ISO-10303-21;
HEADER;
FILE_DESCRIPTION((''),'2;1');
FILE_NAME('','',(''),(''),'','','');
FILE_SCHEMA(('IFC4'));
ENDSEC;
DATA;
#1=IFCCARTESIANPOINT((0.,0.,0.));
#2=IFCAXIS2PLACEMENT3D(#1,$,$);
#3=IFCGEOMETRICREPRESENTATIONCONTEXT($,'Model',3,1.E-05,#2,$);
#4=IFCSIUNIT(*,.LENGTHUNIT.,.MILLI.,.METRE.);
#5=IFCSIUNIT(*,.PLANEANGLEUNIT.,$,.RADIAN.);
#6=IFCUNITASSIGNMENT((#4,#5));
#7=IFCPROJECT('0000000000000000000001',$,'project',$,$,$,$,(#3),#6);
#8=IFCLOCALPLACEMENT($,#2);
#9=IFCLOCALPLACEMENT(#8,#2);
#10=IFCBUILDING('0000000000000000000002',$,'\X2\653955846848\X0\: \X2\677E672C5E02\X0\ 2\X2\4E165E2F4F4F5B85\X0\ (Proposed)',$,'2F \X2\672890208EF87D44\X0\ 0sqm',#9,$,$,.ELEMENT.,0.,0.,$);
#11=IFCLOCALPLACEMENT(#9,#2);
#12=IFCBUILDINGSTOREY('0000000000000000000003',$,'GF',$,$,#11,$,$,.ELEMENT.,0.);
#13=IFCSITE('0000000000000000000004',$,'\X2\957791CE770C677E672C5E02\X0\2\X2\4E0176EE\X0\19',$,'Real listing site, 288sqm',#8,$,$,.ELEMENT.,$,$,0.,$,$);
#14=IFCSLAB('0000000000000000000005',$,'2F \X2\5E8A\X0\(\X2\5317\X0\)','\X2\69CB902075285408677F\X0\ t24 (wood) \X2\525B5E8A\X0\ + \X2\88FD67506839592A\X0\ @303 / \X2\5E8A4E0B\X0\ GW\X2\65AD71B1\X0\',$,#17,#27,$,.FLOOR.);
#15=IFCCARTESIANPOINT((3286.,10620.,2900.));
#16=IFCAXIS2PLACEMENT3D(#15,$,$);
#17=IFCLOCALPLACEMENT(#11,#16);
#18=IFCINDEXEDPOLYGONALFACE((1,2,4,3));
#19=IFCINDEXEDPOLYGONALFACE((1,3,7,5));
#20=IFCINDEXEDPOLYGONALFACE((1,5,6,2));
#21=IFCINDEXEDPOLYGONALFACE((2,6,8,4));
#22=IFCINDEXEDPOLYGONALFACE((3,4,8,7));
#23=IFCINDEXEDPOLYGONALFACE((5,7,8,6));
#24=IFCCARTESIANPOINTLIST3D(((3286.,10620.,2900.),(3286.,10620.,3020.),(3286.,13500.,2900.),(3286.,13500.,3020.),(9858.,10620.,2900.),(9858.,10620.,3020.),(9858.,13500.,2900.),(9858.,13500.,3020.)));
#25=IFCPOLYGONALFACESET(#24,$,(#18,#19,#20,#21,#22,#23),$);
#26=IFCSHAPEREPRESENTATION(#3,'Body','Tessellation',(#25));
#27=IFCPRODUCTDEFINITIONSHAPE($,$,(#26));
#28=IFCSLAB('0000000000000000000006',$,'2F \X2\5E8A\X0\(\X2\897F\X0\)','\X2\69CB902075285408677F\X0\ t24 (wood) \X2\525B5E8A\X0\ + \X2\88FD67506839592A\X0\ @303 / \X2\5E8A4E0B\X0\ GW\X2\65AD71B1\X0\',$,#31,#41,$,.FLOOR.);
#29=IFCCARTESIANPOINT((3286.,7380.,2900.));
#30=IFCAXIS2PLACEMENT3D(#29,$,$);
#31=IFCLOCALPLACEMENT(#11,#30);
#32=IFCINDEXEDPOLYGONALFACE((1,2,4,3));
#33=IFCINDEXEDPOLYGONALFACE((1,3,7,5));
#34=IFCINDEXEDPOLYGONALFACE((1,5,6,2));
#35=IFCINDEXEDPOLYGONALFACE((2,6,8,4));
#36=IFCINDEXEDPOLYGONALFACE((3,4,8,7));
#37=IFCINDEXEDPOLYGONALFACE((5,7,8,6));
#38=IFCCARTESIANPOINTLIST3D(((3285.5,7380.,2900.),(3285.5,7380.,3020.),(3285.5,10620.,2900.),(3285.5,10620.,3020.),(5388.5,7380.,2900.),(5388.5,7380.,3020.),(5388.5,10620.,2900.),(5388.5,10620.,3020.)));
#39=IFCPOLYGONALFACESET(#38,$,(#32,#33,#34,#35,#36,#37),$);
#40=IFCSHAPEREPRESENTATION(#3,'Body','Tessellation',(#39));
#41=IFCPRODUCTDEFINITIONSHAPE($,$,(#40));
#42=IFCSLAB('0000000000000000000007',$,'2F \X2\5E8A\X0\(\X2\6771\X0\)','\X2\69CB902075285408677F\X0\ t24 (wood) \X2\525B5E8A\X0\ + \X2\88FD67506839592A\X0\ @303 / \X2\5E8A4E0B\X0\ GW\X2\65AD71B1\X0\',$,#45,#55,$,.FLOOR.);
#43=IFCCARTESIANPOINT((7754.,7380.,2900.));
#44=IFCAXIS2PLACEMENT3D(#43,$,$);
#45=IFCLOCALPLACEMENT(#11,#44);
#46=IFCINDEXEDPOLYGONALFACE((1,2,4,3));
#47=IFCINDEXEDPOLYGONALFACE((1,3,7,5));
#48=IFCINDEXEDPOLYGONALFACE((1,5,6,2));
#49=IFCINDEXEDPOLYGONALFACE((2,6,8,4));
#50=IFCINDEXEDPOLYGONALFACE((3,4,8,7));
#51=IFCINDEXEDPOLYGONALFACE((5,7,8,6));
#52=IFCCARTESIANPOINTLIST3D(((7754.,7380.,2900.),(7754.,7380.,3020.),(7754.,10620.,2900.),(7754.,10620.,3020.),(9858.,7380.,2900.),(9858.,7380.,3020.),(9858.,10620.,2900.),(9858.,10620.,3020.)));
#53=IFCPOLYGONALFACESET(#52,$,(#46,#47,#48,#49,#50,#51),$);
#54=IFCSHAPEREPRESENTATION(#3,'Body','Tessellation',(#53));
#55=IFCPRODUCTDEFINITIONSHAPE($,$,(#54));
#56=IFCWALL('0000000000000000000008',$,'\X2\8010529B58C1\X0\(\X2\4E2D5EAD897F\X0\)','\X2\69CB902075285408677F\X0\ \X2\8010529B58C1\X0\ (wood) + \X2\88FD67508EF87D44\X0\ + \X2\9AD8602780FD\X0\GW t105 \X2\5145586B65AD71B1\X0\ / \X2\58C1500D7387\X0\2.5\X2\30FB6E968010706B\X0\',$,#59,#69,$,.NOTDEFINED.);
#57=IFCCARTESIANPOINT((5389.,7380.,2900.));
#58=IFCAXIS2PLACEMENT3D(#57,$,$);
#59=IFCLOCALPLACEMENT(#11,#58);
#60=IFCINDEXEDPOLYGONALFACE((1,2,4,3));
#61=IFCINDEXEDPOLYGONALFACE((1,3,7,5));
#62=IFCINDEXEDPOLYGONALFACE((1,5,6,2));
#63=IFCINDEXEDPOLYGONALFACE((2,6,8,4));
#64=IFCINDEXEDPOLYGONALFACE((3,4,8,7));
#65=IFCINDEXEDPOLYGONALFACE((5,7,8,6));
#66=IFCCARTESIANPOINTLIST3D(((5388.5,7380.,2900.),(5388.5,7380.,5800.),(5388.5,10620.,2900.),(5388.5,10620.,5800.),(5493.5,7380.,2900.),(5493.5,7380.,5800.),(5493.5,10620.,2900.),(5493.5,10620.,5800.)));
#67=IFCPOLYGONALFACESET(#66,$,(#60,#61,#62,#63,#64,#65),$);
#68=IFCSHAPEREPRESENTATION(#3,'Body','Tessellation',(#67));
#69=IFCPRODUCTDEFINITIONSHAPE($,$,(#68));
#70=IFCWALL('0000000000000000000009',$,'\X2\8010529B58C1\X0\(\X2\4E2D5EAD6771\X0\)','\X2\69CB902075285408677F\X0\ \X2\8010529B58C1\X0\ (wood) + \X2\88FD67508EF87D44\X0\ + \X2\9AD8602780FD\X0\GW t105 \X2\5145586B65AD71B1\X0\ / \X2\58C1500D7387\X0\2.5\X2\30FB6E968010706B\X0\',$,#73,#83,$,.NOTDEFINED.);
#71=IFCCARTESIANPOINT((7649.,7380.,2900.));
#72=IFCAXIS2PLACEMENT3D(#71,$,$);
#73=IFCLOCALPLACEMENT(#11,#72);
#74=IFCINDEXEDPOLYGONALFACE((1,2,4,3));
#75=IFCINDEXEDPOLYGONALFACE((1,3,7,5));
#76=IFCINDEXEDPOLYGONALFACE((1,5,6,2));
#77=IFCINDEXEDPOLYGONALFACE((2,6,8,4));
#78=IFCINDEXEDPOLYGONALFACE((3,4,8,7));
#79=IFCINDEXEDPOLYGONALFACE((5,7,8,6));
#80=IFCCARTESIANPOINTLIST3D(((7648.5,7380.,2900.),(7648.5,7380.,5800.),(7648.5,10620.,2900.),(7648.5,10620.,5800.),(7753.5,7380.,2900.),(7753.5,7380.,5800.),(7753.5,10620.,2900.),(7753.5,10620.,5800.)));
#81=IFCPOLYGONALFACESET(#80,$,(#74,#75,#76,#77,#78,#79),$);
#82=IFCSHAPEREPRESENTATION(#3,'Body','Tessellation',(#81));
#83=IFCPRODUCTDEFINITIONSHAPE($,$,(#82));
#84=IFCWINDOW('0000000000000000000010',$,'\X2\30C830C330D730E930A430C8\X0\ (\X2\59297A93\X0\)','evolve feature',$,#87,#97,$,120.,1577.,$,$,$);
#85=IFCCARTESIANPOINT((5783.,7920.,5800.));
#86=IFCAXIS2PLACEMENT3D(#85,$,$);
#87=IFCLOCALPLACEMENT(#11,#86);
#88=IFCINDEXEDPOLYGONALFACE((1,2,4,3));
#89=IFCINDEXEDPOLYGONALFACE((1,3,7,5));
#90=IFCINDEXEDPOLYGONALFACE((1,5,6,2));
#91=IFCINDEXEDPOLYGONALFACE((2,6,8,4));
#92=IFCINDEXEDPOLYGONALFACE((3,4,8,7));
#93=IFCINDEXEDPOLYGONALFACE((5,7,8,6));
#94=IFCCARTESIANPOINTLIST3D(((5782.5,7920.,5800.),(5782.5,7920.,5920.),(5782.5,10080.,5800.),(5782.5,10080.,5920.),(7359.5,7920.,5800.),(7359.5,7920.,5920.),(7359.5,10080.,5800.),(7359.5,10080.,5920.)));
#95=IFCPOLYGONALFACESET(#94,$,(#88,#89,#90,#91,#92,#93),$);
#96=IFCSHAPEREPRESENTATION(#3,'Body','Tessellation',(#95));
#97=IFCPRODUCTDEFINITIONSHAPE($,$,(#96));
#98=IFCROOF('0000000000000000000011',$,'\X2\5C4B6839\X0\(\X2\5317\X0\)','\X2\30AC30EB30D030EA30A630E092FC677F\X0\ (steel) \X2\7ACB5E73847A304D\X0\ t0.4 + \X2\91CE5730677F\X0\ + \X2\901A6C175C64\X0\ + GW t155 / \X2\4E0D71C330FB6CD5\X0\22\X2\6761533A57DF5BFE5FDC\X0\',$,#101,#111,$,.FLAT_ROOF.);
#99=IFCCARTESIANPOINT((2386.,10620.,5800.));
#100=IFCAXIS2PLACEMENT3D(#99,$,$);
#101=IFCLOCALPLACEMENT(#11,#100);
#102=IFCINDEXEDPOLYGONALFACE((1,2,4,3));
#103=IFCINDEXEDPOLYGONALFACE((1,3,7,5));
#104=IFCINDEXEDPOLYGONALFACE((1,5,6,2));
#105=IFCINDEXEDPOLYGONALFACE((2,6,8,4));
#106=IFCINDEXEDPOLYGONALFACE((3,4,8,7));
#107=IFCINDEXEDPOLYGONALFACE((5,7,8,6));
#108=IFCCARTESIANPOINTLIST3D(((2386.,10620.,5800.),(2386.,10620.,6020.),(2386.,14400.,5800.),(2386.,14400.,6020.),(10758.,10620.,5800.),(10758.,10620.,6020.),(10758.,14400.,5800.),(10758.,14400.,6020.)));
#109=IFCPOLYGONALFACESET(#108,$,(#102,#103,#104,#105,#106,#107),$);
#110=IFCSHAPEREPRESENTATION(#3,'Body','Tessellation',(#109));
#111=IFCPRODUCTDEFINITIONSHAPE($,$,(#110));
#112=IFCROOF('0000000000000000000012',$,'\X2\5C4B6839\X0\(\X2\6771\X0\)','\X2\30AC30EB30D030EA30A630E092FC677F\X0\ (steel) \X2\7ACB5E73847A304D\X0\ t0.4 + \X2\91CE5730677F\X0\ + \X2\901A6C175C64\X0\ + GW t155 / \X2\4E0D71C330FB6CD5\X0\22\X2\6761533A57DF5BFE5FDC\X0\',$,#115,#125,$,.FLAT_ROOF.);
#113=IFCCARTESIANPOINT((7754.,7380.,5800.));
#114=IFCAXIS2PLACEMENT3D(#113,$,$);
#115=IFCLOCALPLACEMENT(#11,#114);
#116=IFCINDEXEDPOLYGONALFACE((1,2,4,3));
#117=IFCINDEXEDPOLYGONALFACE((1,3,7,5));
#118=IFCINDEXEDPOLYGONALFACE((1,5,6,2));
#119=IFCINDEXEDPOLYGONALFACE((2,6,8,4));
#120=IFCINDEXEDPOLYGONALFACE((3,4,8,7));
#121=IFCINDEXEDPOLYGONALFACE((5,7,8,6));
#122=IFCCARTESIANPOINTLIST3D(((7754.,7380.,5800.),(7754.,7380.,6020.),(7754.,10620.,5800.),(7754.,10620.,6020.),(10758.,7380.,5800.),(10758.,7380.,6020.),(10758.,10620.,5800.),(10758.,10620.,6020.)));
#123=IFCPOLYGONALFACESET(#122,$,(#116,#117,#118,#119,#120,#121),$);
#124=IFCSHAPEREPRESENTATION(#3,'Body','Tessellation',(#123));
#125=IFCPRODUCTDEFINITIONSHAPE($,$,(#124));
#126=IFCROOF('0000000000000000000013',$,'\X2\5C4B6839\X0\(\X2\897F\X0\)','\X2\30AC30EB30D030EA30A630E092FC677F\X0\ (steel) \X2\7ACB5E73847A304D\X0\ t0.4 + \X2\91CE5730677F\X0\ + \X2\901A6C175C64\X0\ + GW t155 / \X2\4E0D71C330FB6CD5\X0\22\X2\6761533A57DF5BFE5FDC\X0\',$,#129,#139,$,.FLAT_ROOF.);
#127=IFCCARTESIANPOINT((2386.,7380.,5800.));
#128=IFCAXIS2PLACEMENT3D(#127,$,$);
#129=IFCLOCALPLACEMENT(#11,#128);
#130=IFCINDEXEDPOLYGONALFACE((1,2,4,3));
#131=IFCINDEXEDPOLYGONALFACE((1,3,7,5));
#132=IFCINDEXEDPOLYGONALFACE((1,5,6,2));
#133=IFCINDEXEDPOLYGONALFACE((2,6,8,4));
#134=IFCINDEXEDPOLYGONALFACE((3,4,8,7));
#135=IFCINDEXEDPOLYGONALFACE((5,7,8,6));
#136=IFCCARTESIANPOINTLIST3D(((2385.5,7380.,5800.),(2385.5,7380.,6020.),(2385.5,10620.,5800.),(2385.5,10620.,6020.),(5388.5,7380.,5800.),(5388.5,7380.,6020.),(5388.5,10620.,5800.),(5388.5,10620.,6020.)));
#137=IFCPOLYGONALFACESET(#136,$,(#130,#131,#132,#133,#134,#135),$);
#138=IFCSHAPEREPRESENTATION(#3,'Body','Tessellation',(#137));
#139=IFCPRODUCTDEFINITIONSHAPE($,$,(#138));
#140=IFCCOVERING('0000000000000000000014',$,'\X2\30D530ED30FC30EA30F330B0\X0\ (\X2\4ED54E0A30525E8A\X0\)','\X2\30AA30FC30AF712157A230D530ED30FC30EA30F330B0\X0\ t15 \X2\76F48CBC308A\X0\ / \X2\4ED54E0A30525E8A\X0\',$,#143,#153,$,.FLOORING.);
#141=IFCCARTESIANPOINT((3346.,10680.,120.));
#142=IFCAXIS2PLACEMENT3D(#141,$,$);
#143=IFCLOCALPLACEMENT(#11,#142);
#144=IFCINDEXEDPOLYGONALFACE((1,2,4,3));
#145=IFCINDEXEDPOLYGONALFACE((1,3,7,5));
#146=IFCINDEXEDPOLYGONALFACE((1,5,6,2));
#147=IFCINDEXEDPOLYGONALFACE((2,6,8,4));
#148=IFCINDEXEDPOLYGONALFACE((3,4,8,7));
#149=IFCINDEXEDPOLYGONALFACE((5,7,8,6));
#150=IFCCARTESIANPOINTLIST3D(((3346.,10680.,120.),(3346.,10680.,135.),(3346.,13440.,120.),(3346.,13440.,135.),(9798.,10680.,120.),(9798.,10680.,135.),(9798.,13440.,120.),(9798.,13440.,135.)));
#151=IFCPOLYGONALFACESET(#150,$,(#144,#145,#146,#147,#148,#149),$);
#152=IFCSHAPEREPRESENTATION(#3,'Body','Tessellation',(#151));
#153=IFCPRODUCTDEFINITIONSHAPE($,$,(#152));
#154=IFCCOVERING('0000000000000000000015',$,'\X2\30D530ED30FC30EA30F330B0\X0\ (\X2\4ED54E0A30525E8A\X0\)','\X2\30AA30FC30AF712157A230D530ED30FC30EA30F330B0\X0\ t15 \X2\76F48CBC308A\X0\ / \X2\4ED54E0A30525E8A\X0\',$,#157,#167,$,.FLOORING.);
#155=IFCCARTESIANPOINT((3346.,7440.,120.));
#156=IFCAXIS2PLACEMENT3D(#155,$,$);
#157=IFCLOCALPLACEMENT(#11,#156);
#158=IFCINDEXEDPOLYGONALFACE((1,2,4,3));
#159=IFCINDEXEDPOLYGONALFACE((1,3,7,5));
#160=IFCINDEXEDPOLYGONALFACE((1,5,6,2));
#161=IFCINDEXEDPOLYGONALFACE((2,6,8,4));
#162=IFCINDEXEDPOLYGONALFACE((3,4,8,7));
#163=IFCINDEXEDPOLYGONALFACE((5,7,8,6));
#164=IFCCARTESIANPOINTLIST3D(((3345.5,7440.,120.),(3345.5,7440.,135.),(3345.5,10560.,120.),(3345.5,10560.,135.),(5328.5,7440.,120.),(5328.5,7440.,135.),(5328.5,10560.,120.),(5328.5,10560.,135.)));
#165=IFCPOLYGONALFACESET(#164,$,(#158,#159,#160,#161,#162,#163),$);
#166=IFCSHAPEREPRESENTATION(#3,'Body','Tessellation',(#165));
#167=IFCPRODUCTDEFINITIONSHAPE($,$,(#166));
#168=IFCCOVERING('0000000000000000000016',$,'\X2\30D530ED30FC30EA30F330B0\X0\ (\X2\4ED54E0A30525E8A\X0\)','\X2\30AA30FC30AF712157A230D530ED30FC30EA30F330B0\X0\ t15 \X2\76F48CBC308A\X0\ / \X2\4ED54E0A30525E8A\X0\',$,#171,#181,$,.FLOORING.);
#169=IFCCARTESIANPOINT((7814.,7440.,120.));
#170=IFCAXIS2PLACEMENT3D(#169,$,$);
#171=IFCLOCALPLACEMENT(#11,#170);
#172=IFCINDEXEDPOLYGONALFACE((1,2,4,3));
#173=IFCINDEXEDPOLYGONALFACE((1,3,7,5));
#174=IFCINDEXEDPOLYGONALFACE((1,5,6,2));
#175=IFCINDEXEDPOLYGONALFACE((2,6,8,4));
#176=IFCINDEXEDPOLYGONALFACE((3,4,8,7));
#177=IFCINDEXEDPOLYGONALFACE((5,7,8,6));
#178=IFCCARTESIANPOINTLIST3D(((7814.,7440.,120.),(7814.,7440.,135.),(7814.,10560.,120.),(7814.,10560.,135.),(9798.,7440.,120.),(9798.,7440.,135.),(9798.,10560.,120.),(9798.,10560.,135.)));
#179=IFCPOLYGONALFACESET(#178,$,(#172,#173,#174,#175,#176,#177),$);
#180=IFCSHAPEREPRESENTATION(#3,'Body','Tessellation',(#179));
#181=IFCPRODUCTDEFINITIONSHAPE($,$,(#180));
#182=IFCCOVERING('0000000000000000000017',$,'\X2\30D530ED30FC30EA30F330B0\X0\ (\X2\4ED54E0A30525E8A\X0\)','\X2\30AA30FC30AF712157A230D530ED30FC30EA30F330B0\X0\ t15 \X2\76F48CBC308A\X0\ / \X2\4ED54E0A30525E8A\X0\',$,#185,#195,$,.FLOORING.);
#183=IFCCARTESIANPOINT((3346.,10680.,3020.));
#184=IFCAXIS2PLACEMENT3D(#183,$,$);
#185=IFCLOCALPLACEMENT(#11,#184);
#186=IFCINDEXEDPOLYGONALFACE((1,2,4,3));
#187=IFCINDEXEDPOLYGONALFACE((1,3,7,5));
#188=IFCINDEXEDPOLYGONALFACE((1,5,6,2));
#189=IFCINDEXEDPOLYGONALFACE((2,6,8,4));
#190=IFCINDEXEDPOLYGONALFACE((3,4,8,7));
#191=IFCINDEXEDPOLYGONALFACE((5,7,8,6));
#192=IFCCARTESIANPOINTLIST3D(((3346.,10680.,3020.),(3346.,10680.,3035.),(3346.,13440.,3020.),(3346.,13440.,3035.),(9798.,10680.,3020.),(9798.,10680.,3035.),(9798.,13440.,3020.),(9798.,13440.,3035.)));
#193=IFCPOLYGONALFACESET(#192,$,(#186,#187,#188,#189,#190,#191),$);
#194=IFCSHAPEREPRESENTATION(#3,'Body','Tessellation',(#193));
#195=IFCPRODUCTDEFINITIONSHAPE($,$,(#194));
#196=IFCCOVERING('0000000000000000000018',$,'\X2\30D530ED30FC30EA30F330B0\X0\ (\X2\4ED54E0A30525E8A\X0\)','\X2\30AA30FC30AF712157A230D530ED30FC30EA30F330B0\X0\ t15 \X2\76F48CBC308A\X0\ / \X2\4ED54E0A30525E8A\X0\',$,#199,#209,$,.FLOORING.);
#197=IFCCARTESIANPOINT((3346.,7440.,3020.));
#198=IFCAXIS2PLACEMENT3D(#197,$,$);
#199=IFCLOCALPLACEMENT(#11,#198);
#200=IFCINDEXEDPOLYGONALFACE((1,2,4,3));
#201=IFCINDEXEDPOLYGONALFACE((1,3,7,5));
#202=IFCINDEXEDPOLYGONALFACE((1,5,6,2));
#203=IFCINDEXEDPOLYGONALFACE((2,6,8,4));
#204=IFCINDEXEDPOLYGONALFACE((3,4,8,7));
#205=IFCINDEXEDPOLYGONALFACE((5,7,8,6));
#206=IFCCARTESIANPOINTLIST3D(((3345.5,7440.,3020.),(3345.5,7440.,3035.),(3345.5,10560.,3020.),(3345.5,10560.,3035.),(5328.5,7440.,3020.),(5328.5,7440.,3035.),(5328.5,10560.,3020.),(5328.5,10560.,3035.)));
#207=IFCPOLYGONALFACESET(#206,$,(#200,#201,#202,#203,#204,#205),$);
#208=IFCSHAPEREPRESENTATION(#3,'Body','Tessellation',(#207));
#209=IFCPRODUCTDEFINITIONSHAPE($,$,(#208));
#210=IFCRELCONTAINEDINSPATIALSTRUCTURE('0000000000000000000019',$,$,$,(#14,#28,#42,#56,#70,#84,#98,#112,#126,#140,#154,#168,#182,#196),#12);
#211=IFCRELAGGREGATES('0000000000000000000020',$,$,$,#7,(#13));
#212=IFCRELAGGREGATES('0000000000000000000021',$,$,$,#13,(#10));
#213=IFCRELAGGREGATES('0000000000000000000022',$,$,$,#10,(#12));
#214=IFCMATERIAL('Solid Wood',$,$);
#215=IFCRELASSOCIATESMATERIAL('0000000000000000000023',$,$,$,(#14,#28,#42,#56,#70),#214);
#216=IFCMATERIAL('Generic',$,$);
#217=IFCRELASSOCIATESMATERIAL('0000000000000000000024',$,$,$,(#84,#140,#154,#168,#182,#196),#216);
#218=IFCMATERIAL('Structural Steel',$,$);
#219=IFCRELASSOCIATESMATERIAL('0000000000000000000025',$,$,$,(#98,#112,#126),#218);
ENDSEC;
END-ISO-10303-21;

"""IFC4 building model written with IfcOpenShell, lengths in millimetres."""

from ifc_helpers import new_model, si_unit, frame, frame_2d, origin, place, context, project, spatial, rectangle, extrude, material, element, save


model = new_model("IFC4")

# Units and contexts
model_context = context("Model", 3, precision=1e-05, world=origin())
ifc_project = project(units=[si_unit("LENGTHUNIT", "METRE", prefix="MILLI"), si_unit("PLANEANGLEUNIT", "RADIAN")], contexts=[model_context])

# Site, building, storey
site_placement = place(None, origin())
site = spatial("IfcSite", under=ifc_project, at=site_placement, Name="長野県松本市2丁目19", ObjectType="Real listing site, 288sqm", CompositionType="ELEMENT", RefElevation=0.0)
building_placement = place(site_placement, origin())
building = spatial("IfcBuilding", under=site, at=building_placement, Name="改善案: 松本市 2世帯住宅 (Proposed)", ObjectType="2F 木造軸組 0sqm", CompositionType="ELEMENT", ElevationOfRefHeight=0.0, ElevationOfTerrain=0.0)
storey_placement = place(building_placement, origin())
storey = spatial("IfcBuildingStorey", under=building, at=storey_placement, Name="GF", CompositionType="ELEMENT", Elevation=0.0)

# Slabs
ifc_material_1 = material(Name="Solid Wood")
slab_1_placement = place(storey_placement, frame((3286.0, 10620.0, 2900.0)))
element("IfcSlab", 1, at=slab_1_placement, inside=storey, material=ifc_material_1, Name="2F 床(北)", Description="構造用合板 t24 (wood) 剛床 + 製材根太 @303 / 床下 GW断熱", PredefinedType="FLOOR", context=model_context, shape_type="SweptSolid", body=[
    extrude(rectangle(XDim=6572.0, YDim=2880.0, at=frame_2d((3286.0, 1440.0))), frame((3286.0, 10620.0, 2900.0)), (0.0, 0.0, 1.0), 120.0),
])
slab_2_placement = place(storey_placement, frame((3286.0, 7380.0, 2900.0)))
element("IfcSlab", 2, at=slab_2_placement, inside=storey, material=ifc_material_1, Name="2F 床(西)", Description="構造用合板 t24 (wood) 剛床 + 製材根太 @303 / 床下 GW断熱", PredefinedType="FLOOR", context=model_context, shape_type="SweptSolid", body=[
    extrude(rectangle(XDim=2103.0, YDim=3240.0, at=frame_2d((1051.0, 1620.0))), frame((3286.0, 7380.0, 2900.0)), (0.0, 0.0, 1.0), 120.0),
])
slab_3_placement = place(storey_placement, frame((7754.0, 7380.0, 2900.0)))
element("IfcSlab", 3, at=slab_3_placement, inside=storey, material=ifc_material_1, Name="2F 床(東)", Description="構造用合板 t24 (wood) 剛床 + 製材根太 @303 / 床下 GW断熱", PredefinedType="FLOOR", context=model_context, shape_type="SweptSolid", body=[
    extrude(rectangle(XDim=2104.0, YDim=3240.0, at=frame_2d((1052.0, 1620.0))), frame((7754.0, 7380.0, 2900.0)), (0.0, 0.0, 1.0), 120.0),
])

# Walls
wall_1_placement = place(storey_placement, frame((5389.0, 7380.0, 2900.0)))
element("IfcWall", 4, at=wall_1_placement, inside=storey, material=ifc_material_1, Name="耐力壁(中庭西)", Description="構造用合板 耐力壁 (wood) + 製材軸組 + 高性能GW t105 充填断熱 / 壁倍率2.5・準耐火", PredefinedType="NOTDEFINED", context=model_context, shape_type="SweptSolid", body=[
    extrude(rectangle(XDim=105.0, YDim=3240.0, at=frame_2d((52.0, 1620.0))), frame((5389.0, 7380.0, 2900.0)), (0.0, 0.0, 1.0), 2900.0),
])
wall_2_placement = place(storey_placement, frame((7649.0, 7380.0, 2900.0)))
element("IfcWall", 5, at=wall_2_placement, inside=storey, material=ifc_material_1, Name="耐力壁(中庭東)", Description="構造用合板 耐力壁 (wood) + 製材軸組 + 高性能GW t105 充填断熱 / 壁倍率2.5・準耐火", PredefinedType="NOTDEFINED", context=model_context, shape_type="SweptSolid", body=[
    extrude(rectangle(XDim=105.0, YDim=3240.0, at=frame_2d((52.0, 1620.0))), frame((7649.0, 7380.0, 2900.0)), (0.0, 0.0, 1.0), 2900.0),
])

# Window
ifc_material_2 = material(Name="Generic")
window_1_placement = place(storey_placement, frame((5783.0, 7920.0, 5800.0)))
element("IfcWindow", 6, at=window_1_placement, inside=storey, material=ifc_material_2, Name="トップライト (天窓)", Description="evolve feature", OverallHeight=120.0, OverallWidth=1577.0, context=model_context, shape_type="SweptSolid", body=[
    extrude(rectangle(XDim=1577.0, YDim=2160.0, at=frame_2d((788.0, 1080.0))), frame((5783.0, 7920.0, 5800.0)), (0.0, 0.0, 1.0), 120.0),
])

# Roofs
ifc_material_3 = material(Name="Structural Steel")
roof_1_placement = place(storey_placement, frame((2386.0, 10620.0, 5800.0)))
element("IfcRoof", 7, at=roof_1_placement, inside=storey, material=ifc_material_3, Name="屋根(北)", Description="ガルバリウム鋼板 (steel) 立平葺き t0.4 + 野地板 + 通気層 + GW t155 / 不燃・法22条区域対応", PredefinedType="FLAT_ROOF", context=model_context, shape_type="SweptSolid", body=[
    extrude(rectangle(XDim=8372.0, YDim=3780.0, at=frame_2d((4186.0, 1890.0))), frame((2386.0, 10620.0, 5800.0)), (0.0, 0.0, 1.0), 220.0),
])
roof_2_placement = place(storey_placement, frame((7754.0, 7380.0, 5800.0)))
element("IfcRoof", 8, at=roof_2_placement, inside=storey, material=ifc_material_3, Name="屋根(東)", Description="ガルバリウム鋼板 (steel) 立平葺き t0.4 + 野地板 + 通気層 + GW t155 / 不燃・法22条区域対応", PredefinedType="FLAT_ROOF", context=model_context, shape_type="SweptSolid", body=[
    extrude(rectangle(XDim=3004.0, YDim=3240.0, at=frame_2d((1502.0, 1620.0))), frame((7754.0, 7380.0, 5800.0)), (0.0, 0.0, 1.0), 220.0),
])
roof_3_placement = place(storey_placement, frame((2386.0, 7380.0, 5800.0)))
element("IfcRoof", 9, at=roof_3_placement, inside=storey, material=ifc_material_3, Name="屋根(西)", Description="ガルバリウム鋼板 (steel) 立平葺き t0.4 + 野地板 + 通気層 + GW t155 / 不燃・法22条区域対応", PredefinedType="FLAT_ROOF", context=model_context, shape_type="SweptSolid", body=[
    extrude(rectangle(XDim=3003.0, YDim=3240.0, at=frame_2d((1501.0, 1620.0))), frame((2386.0, 7380.0, 5800.0)), (0.0, 0.0, 1.0), 220.0),
])

# Coverings
covering_1_placement = place(storey_placement, frame((3346.0, 10680.0, 120.0)))
element("IfcCovering", 10, at=covering_1_placement, inside=storey, material=ifc_material_2, Name="フローリング (仕上げ床)", Description="オーク無垢フローリング t15 直貼り / 仕上げ床", PredefinedType="FLOORING", context=model_context, shape_type="SweptSolid", body=[
    extrude(rectangle(XDim=6452.0, YDim=2760.0, at=frame_2d((3226.0, 1380.0))), frame((3346.0, 10680.0, 120.0)), (0.0, 0.0, 1.0), 15.0),
])
covering_2_placement = place(storey_placement, frame((3346.0, 7440.0, 120.0)))
element("IfcCovering", 11, at=covering_2_placement, inside=storey, material=ifc_material_2, Name="フローリング (仕上げ床)", Description="オーク無垢フローリング t15 直貼り / 仕上げ床", PredefinedType="FLOORING", context=model_context, shape_type="SweptSolid", body=[
    extrude(rectangle(XDim=1983.0, YDim=3120.0, at=frame_2d((991.0, 1560.0))), frame((3346.0, 7440.0, 120.0)), (0.0, 0.0, 1.0), 15.0),
])
covering_3_placement = place(storey_placement, frame((7814.0, 7440.0, 120.0)))
element("IfcCovering", 12, at=covering_3_placement, inside=storey, material=ifc_material_2, Name="フローリング (仕上げ床)", Description="オーク無垢フローリング t15 直貼り / 仕上げ床", PredefinedType="FLOORING", context=model_context, shape_type="SweptSolid", body=[
    extrude(rectangle(XDim=1984.0, YDim=3120.0, at=frame_2d((992.0, 1560.0))), frame((7814.0, 7440.0, 120.0)), (0.0, 0.0, 1.0), 15.0),
])
covering_4_placement = place(storey_placement, frame((3346.0, 10680.0, 3020.0)))
element("IfcCovering", 13, at=covering_4_placement, inside=storey, material=ifc_material_2, Name="フローリング (仕上げ床)", Description="オーク無垢フローリング t15 直貼り / 仕上げ床", PredefinedType="FLOORING", context=model_context, shape_type="SweptSolid", body=[
    extrude(rectangle(XDim=6452.0, YDim=2760.0, at=frame_2d((3226.0, 1380.0))), frame((3346.0, 10680.0, 3020.0)), (0.0, 0.0, 1.0), 15.0),
])
covering_5_placement = place(storey_placement, frame((3346.0, 7440.0, 3020.0)))
element("IfcCovering", 14, at=covering_5_placement, inside=storey, material=ifc_material_2, Name="フローリング (仕上げ床)", Description="オーク無垢フローリング t15 直貼り / 仕上げ床", PredefinedType="FLOORING", context=model_context, shape_type="SweptSolid", body=[
    extrude(rectangle(XDim=1983.0, YDim=3120.0, at=frame_2d((991.0, 1560.0))), frame((3346.0, 7440.0, 3020.0)), (0.0, 0.0, 1.0), 15.0),
])

save(model, "model.ifc")
